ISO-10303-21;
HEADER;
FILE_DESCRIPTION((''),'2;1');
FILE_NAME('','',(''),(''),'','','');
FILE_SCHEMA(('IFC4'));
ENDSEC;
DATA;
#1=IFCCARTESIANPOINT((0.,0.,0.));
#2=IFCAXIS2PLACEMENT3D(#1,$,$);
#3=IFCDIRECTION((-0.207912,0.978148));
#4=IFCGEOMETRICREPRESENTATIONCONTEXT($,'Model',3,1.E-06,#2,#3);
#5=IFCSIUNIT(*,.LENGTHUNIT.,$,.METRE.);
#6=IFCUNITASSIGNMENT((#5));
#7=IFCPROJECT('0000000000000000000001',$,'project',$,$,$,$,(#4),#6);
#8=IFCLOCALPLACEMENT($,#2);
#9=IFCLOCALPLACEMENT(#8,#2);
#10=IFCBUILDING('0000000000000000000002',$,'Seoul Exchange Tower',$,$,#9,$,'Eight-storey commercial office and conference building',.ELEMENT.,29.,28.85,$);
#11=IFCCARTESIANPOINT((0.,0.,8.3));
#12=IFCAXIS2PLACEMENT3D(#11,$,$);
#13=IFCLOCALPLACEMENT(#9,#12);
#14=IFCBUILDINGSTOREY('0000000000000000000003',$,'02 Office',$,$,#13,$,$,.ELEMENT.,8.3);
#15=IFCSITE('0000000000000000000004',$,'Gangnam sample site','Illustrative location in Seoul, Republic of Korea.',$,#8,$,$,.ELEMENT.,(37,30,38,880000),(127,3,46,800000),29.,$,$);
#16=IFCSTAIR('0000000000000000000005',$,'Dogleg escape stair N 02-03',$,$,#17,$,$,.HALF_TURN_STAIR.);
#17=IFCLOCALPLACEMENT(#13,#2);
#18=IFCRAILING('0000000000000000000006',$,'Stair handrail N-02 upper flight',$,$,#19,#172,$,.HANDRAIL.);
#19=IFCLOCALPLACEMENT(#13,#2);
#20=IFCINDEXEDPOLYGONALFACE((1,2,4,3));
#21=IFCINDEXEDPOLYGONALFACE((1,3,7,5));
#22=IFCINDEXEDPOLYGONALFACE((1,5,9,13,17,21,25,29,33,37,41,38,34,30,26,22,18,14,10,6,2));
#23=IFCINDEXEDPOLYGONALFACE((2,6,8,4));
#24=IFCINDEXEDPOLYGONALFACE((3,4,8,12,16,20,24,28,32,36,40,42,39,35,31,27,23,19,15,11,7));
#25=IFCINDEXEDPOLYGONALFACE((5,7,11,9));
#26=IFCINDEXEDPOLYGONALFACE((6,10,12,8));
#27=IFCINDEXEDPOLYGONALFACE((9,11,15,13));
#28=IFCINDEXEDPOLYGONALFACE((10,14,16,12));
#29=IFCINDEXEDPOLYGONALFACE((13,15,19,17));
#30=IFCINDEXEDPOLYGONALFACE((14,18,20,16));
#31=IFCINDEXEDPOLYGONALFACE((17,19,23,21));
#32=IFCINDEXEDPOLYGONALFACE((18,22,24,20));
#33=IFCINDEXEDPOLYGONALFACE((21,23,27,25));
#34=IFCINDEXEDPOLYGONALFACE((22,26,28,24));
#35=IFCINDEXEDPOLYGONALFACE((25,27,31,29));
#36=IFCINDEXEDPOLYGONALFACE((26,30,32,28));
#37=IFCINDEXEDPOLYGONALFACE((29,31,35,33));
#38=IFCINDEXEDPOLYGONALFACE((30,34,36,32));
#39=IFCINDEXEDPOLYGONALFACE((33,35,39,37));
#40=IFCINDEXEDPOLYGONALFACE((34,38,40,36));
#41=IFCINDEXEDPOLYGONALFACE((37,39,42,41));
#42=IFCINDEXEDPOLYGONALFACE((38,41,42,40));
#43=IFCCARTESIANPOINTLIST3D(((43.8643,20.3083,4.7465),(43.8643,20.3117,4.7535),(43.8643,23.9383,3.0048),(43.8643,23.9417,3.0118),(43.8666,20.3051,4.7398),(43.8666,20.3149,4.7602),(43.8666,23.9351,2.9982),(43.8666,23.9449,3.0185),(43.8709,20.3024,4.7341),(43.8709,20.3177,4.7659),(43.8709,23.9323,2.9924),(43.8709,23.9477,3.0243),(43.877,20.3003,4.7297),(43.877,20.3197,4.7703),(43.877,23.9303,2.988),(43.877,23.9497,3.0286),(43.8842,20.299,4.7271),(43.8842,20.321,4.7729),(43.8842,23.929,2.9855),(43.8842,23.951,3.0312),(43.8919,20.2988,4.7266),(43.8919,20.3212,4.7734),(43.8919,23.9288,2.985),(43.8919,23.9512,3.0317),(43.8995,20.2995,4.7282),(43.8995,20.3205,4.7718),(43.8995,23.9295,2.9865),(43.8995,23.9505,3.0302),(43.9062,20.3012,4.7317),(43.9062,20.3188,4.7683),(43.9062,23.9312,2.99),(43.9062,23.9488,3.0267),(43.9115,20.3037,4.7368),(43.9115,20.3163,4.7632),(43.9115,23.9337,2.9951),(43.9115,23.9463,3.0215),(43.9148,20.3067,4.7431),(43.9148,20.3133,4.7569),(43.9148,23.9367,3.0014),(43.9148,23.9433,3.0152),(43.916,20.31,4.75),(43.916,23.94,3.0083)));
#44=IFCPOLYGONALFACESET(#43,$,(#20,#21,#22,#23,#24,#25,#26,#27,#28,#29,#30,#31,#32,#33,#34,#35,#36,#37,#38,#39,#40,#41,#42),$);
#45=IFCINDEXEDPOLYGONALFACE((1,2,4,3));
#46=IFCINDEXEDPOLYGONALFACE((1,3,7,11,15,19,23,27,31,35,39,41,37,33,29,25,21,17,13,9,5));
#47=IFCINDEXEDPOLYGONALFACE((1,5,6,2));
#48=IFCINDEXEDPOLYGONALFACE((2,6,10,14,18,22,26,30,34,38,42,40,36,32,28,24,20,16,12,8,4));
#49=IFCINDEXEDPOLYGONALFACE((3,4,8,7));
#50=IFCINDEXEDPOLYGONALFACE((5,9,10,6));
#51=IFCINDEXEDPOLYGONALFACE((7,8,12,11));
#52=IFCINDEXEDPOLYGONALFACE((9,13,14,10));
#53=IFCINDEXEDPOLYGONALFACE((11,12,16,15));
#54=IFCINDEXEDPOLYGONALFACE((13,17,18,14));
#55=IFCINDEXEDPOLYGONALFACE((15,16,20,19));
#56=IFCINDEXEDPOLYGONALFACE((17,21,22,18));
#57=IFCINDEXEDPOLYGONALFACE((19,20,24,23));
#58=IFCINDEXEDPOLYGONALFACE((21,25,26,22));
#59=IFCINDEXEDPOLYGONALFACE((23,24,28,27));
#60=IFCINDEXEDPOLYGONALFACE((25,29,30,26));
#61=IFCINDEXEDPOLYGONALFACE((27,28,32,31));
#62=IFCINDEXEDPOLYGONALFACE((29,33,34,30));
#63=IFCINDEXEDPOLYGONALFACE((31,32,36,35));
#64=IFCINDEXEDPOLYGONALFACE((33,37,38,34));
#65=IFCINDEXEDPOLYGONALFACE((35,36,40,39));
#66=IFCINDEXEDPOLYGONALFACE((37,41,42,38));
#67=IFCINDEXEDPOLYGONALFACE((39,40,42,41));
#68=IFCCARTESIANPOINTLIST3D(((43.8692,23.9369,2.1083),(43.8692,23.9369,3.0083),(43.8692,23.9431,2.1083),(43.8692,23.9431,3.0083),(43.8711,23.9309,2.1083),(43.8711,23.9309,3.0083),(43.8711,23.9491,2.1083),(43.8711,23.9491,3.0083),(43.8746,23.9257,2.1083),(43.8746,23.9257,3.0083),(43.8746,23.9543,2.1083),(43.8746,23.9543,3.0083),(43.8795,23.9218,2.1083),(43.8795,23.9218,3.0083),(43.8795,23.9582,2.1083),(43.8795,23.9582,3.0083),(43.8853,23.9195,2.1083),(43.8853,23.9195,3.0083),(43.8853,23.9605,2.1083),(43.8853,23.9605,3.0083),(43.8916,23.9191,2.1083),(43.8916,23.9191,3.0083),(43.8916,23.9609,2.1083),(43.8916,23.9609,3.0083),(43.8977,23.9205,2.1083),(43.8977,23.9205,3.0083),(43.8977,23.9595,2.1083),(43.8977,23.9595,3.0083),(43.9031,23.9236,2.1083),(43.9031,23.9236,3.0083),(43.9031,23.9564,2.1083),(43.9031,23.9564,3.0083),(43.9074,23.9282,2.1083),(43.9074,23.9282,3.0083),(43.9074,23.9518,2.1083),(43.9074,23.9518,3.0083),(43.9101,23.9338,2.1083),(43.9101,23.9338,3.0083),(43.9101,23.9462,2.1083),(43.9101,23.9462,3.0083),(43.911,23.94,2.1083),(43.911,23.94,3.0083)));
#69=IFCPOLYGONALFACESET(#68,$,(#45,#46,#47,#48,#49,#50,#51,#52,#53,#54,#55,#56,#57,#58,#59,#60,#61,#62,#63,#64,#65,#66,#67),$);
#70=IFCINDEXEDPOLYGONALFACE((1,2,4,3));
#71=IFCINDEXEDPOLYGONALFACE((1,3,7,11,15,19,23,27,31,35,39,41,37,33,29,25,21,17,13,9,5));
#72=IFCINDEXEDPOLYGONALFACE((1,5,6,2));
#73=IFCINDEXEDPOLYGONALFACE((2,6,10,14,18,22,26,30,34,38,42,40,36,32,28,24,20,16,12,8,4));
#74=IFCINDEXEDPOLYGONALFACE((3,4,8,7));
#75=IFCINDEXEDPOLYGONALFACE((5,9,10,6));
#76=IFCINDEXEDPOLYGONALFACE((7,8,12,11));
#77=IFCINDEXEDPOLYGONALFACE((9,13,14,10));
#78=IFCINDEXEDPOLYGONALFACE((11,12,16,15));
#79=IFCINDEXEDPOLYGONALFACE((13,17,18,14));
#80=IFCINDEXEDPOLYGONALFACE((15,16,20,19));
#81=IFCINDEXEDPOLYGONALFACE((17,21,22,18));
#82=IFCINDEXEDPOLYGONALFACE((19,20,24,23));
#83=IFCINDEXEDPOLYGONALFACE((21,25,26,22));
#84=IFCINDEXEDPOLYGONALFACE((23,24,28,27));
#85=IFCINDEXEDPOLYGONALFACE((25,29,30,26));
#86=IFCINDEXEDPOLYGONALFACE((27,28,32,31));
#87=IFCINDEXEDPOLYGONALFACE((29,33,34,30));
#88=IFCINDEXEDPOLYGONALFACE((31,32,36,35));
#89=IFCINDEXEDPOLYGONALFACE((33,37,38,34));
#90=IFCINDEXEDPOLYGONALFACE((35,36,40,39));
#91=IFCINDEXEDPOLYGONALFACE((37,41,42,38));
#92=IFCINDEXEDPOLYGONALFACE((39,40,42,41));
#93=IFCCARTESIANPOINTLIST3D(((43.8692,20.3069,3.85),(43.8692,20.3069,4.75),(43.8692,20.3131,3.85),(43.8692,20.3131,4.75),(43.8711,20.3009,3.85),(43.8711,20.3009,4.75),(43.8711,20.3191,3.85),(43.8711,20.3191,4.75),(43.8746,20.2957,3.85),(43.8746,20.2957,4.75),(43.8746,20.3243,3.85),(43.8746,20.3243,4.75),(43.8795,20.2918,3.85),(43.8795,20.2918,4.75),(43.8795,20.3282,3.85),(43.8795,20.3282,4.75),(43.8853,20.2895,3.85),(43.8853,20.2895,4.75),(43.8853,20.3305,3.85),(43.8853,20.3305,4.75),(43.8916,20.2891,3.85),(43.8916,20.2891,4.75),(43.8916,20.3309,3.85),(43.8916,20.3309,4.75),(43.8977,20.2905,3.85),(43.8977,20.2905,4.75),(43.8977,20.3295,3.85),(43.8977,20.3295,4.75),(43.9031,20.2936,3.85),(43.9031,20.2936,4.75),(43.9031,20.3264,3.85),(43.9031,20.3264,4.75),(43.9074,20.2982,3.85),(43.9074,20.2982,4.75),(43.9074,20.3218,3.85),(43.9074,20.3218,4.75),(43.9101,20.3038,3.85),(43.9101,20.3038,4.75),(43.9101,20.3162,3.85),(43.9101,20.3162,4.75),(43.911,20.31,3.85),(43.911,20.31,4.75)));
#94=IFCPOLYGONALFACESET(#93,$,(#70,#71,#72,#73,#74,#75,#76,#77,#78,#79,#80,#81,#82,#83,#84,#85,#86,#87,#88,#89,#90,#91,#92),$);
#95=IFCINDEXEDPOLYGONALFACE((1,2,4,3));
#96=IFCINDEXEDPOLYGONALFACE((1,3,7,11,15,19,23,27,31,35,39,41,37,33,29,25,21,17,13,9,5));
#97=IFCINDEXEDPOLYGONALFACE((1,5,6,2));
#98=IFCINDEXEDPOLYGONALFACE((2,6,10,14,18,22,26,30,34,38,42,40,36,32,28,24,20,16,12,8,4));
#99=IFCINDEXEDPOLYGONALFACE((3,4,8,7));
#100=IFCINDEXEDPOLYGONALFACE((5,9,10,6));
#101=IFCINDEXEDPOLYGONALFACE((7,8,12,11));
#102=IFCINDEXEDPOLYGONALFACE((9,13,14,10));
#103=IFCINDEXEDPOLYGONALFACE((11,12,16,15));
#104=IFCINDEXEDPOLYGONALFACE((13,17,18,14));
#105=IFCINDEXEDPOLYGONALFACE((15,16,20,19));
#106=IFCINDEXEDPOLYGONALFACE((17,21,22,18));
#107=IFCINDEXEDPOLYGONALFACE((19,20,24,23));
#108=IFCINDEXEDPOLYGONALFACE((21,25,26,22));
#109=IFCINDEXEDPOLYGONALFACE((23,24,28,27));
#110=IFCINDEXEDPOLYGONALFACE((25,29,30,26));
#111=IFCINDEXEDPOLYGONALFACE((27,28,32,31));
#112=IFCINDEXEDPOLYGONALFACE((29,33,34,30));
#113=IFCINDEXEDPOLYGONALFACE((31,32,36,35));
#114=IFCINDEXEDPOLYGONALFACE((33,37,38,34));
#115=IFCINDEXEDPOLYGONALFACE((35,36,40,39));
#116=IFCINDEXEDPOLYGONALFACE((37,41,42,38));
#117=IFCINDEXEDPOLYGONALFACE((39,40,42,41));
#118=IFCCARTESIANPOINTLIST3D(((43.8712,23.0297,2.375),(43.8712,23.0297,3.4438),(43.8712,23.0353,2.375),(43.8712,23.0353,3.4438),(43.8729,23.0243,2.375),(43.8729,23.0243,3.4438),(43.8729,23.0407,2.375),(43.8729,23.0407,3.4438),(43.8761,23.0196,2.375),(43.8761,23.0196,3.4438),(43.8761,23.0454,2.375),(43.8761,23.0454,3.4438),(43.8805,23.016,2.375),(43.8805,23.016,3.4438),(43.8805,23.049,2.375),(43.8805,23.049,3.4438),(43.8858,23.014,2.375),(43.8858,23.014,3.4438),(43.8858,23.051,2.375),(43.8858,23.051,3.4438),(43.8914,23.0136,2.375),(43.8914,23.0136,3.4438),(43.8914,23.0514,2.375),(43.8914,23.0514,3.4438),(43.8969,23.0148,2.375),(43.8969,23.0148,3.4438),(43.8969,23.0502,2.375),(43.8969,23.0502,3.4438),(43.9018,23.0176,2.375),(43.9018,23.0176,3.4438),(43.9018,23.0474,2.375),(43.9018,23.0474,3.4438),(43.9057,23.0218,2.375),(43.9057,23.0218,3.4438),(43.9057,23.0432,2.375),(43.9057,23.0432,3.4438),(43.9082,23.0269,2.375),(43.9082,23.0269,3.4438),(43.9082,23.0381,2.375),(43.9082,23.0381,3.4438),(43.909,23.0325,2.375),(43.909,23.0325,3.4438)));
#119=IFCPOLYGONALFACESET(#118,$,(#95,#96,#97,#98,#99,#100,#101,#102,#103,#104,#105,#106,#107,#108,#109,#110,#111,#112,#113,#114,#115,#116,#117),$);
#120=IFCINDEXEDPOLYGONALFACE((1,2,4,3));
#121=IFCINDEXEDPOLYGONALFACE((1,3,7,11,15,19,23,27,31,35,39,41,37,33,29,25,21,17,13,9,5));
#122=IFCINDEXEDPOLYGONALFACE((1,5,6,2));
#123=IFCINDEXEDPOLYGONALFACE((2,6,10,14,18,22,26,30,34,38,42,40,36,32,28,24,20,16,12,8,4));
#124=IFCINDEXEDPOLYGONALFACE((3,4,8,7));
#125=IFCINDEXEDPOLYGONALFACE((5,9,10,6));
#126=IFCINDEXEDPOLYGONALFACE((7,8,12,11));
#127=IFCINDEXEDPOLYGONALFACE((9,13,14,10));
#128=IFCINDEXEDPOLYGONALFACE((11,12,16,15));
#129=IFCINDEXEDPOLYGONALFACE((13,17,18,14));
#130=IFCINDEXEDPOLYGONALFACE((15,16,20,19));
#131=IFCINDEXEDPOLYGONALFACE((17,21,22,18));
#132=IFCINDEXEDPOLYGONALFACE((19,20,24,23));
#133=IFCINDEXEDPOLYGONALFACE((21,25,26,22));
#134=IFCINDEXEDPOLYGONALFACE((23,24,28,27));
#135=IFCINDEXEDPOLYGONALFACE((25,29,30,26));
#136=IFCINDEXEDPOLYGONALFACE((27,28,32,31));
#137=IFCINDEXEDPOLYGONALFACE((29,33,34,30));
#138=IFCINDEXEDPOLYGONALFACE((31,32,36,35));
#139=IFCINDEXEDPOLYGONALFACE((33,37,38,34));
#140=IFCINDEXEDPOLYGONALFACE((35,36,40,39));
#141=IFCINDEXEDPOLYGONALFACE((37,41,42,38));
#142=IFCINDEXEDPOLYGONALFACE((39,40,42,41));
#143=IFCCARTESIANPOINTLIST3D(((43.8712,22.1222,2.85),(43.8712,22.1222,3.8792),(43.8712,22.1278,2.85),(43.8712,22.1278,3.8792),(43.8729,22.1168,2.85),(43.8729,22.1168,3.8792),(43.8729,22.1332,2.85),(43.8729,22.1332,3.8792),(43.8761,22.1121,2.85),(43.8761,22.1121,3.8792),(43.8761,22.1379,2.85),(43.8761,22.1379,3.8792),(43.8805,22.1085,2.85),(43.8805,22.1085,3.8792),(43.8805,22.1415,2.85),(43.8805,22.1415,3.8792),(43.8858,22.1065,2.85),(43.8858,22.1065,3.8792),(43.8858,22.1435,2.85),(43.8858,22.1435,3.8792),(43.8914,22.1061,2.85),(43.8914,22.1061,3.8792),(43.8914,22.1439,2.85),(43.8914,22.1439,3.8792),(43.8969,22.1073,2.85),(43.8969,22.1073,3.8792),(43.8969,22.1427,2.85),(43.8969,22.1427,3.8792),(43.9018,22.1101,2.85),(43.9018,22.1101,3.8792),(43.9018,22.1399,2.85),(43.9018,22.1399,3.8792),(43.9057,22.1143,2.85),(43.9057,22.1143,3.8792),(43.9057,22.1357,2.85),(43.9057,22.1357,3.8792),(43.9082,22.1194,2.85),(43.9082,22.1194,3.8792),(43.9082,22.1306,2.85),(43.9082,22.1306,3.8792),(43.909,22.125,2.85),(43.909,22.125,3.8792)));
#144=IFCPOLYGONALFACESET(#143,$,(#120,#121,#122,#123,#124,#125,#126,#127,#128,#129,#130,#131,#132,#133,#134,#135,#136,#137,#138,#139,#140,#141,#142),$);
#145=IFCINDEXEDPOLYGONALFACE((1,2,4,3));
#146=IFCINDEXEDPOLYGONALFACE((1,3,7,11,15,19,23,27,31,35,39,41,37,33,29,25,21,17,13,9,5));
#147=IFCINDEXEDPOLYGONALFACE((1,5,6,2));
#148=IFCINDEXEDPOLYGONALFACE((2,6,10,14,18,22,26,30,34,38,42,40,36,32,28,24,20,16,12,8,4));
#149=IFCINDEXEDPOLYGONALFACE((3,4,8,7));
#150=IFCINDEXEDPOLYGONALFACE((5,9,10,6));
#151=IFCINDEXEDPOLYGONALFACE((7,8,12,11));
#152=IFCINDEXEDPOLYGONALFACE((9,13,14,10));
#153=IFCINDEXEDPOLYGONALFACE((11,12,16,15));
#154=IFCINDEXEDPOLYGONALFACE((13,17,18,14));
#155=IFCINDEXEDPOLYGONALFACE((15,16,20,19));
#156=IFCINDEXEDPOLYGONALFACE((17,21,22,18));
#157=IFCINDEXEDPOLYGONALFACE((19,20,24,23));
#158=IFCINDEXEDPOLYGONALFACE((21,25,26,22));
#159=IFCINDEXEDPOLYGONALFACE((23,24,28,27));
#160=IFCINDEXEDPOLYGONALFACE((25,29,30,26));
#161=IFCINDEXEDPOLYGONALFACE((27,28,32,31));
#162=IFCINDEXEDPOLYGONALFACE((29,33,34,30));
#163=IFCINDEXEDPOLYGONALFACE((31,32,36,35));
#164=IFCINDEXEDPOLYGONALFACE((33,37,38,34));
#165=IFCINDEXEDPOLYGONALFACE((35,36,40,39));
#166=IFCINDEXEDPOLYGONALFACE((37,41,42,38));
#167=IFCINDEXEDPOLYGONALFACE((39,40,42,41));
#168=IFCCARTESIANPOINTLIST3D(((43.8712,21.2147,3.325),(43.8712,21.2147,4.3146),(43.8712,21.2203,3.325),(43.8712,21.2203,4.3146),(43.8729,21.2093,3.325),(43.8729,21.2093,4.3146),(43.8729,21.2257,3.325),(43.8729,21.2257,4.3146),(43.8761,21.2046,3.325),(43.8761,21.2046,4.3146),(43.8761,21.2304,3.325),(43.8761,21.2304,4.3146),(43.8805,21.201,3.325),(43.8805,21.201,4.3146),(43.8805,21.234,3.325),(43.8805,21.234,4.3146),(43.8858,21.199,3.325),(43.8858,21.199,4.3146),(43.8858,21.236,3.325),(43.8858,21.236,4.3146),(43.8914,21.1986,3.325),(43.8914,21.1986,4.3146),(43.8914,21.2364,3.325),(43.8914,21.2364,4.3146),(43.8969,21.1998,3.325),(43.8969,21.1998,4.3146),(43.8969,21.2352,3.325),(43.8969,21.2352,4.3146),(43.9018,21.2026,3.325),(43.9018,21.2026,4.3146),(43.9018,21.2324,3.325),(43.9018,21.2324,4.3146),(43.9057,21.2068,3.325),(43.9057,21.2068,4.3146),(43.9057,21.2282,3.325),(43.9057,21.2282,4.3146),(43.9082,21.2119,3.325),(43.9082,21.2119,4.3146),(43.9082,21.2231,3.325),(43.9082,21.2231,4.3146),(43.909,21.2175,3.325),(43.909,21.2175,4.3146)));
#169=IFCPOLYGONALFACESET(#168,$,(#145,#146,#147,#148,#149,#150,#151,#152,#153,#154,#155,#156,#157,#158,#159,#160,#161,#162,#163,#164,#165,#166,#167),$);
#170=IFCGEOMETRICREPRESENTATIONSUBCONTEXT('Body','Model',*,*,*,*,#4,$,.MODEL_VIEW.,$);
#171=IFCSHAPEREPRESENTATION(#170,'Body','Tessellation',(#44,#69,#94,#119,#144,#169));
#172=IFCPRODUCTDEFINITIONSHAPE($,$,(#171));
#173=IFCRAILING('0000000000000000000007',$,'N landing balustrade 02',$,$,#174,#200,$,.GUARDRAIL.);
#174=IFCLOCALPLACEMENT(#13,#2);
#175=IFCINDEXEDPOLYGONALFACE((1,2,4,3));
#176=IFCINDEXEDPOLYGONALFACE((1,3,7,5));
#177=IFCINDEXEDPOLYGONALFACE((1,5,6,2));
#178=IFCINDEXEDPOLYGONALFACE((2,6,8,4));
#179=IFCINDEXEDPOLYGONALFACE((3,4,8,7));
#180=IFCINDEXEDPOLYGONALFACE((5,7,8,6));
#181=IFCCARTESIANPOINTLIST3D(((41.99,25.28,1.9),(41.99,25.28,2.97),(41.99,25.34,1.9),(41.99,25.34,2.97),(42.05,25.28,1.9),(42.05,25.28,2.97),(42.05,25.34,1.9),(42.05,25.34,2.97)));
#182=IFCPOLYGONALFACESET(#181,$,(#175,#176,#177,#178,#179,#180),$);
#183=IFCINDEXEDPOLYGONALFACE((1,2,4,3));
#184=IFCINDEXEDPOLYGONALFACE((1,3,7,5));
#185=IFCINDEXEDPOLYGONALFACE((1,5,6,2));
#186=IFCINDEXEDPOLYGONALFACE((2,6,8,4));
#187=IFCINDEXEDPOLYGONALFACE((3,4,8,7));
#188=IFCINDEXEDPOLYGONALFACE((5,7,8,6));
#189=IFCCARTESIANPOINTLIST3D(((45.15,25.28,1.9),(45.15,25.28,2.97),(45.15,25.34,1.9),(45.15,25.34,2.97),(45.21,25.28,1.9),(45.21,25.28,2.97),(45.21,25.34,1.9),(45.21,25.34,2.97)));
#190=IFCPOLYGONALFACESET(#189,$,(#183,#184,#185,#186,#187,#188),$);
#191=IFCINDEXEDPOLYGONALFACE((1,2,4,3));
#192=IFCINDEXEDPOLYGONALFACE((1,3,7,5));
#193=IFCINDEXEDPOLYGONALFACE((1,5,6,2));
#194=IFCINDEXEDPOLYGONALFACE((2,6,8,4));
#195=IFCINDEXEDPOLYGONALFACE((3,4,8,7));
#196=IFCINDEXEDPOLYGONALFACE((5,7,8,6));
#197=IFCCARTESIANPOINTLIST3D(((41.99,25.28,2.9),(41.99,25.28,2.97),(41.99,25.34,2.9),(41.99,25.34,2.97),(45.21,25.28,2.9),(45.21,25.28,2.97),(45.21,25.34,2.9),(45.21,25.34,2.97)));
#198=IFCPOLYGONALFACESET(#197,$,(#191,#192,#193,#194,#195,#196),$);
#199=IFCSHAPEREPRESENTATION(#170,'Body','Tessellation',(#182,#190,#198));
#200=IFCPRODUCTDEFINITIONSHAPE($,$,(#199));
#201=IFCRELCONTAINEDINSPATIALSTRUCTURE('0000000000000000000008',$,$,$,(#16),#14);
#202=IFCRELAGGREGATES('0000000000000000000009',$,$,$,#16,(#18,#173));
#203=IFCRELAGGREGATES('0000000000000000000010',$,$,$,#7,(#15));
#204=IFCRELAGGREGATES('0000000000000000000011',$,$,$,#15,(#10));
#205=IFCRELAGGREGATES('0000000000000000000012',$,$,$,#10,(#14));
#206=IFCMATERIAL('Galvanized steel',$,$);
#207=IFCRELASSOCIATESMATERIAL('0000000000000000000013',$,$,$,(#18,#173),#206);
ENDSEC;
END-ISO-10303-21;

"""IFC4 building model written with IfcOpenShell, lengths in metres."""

from ifc_helpers import new_model, si_unit, direction, frame, frame_2d, origin, place, context, subcontext, project, spatial, rectangle, circle, extrude, material, element, aggregate, save


model = new_model("IFC4")

# Units and contexts
model_context = context("Model", 3, precision=1e-06, world=origin(), true_north=direction((-0.207912, 0.978148)))
body_context = subcontext(model_context, "Body", "Model", "MODEL_VIEW")
ifc_project = project(units=[si_unit("LENGTHUNIT", "METRE")], contexts=[model_context])

# Site, building, storey
site_placement = place(None, origin())
site = spatial("IfcSite", under=ifc_project, at=site_placement, Name="Gangnam sample site", Description="Illustrative location in Seoul, Republic of Korea.", CompositionType="ELEMENT", RefLatitude=(37, 30, 38, 880000), RefLongitude=(127, 3, 46, 800000), RefElevation=29.0)
building_placement = place(site_placement, origin())
building = spatial("IfcBuilding", under=site, at=building_placement, Name="Seoul Exchange Tower", LongName="Eight-storey commercial office and conference building", CompositionType="ELEMENT", ElevationOfRefHeight=29.0, ElevationOfTerrain=28.85)
storey_placement = place(building_placement, frame((0.0, 0.0, 8.3)))
storey = spatial("IfcBuildingStorey", under=building, at=storey_placement, Name="02 Office", CompositionType="ELEMENT", Elevation=8.3)

# Shared definitions
placement_1 = place(storey_placement, origin())

# Stair
stair_1 = element("IfcStair", 1, at=placement_1, inside=storey, Name="Dogleg escape stair N 02-03", PredefinedType="HALF_TURN_STAIR")
placement_2 = place(placement_1, origin())

# Railings
ifc_material_1 = material(Name="Galvanized steel")
railing_1 = element("IfcRailing", 2, at=placement_2, material=ifc_material_1, Name="Stair handrail N-02 upper flight", PredefinedType="HANDRAIL", context=body_context, shape_type="SweptSolid", body=[
    extrude(circle(Radius=0.026), frame((43.89, 23.94, 3.0083), z_axis=(0.0, -0.901594, 0.432583), x_axis=(1.0, 0.0, 0.0)), (0.0, 0.0, 1.0), 4.0262),
    extrude(circle(Radius=0.021), frame((43.89, 23.94, 2.1083), z_axis=(0.0, 0.0, 1.0), x_axis=(1.0, 0.0, 0.0)), (0.0, 0.0, 1.0), 0.9),
    extrude(circle(Radius=0.021), frame((43.89, 20.31, 3.85), z_axis=(0.0, 0.0, 1.0), x_axis=(1.0, 0.0, 0.0)), (0.0, 0.0, 1.0), 0.9),
    extrude(circle(Radius=0.019), frame((43.89, 23.0325, 2.375), z_axis=(0.0, 0.0, 1.0), x_axis=(1.0, 0.0, 0.0)), (0.0, 0.0, 1.0), 1.0688),
    extrude(circle(Radius=0.019), frame((43.89, 22.125, 2.85), z_axis=(0.0, 0.0, 1.0), x_axis=(1.0, 0.0, 0.0)), (0.0, 0.0, 1.0), 1.0292),
    extrude(circle(Radius=0.019), frame((43.89, 21.2175, 3.325), z_axis=(0.0, 0.0, 1.0), x_axis=(1.0, 0.0, 0.0)), (0.0, 0.0, 1.0), 0.9896),
])
railing_2 = element("IfcRailing", 3, at=placement_2, material=ifc_material_1, Name="N landing balustrade 02", PredefinedType="GUARDRAIL", context=body_context, shape_type="SweptSolid", body=[
    extrude(rectangle(XDim=0.06, YDim=0.06, at=frame_2d((0.03, 0.03))), frame((41.99, 25.28, 1.9)), (0.0, 0.0, 1.0), 1.07),
    extrude(rectangle(XDim=0.06, YDim=0.06, at=frame_2d((0.03, 0.03))), frame((45.15, 25.28, 1.9)), (0.0, 0.0, 1.0), 1.07),
    extrude(rectangle(XDim=3.22, YDim=0.06, at=frame_2d((1.61, 0.03))), frame((41.99, 25.28, 2.9)), (0.0, 0.0, 1.0), 0.07),
])
aggregate(stair_1, [railing_1, railing_2])

save(model, "model.ifc")
